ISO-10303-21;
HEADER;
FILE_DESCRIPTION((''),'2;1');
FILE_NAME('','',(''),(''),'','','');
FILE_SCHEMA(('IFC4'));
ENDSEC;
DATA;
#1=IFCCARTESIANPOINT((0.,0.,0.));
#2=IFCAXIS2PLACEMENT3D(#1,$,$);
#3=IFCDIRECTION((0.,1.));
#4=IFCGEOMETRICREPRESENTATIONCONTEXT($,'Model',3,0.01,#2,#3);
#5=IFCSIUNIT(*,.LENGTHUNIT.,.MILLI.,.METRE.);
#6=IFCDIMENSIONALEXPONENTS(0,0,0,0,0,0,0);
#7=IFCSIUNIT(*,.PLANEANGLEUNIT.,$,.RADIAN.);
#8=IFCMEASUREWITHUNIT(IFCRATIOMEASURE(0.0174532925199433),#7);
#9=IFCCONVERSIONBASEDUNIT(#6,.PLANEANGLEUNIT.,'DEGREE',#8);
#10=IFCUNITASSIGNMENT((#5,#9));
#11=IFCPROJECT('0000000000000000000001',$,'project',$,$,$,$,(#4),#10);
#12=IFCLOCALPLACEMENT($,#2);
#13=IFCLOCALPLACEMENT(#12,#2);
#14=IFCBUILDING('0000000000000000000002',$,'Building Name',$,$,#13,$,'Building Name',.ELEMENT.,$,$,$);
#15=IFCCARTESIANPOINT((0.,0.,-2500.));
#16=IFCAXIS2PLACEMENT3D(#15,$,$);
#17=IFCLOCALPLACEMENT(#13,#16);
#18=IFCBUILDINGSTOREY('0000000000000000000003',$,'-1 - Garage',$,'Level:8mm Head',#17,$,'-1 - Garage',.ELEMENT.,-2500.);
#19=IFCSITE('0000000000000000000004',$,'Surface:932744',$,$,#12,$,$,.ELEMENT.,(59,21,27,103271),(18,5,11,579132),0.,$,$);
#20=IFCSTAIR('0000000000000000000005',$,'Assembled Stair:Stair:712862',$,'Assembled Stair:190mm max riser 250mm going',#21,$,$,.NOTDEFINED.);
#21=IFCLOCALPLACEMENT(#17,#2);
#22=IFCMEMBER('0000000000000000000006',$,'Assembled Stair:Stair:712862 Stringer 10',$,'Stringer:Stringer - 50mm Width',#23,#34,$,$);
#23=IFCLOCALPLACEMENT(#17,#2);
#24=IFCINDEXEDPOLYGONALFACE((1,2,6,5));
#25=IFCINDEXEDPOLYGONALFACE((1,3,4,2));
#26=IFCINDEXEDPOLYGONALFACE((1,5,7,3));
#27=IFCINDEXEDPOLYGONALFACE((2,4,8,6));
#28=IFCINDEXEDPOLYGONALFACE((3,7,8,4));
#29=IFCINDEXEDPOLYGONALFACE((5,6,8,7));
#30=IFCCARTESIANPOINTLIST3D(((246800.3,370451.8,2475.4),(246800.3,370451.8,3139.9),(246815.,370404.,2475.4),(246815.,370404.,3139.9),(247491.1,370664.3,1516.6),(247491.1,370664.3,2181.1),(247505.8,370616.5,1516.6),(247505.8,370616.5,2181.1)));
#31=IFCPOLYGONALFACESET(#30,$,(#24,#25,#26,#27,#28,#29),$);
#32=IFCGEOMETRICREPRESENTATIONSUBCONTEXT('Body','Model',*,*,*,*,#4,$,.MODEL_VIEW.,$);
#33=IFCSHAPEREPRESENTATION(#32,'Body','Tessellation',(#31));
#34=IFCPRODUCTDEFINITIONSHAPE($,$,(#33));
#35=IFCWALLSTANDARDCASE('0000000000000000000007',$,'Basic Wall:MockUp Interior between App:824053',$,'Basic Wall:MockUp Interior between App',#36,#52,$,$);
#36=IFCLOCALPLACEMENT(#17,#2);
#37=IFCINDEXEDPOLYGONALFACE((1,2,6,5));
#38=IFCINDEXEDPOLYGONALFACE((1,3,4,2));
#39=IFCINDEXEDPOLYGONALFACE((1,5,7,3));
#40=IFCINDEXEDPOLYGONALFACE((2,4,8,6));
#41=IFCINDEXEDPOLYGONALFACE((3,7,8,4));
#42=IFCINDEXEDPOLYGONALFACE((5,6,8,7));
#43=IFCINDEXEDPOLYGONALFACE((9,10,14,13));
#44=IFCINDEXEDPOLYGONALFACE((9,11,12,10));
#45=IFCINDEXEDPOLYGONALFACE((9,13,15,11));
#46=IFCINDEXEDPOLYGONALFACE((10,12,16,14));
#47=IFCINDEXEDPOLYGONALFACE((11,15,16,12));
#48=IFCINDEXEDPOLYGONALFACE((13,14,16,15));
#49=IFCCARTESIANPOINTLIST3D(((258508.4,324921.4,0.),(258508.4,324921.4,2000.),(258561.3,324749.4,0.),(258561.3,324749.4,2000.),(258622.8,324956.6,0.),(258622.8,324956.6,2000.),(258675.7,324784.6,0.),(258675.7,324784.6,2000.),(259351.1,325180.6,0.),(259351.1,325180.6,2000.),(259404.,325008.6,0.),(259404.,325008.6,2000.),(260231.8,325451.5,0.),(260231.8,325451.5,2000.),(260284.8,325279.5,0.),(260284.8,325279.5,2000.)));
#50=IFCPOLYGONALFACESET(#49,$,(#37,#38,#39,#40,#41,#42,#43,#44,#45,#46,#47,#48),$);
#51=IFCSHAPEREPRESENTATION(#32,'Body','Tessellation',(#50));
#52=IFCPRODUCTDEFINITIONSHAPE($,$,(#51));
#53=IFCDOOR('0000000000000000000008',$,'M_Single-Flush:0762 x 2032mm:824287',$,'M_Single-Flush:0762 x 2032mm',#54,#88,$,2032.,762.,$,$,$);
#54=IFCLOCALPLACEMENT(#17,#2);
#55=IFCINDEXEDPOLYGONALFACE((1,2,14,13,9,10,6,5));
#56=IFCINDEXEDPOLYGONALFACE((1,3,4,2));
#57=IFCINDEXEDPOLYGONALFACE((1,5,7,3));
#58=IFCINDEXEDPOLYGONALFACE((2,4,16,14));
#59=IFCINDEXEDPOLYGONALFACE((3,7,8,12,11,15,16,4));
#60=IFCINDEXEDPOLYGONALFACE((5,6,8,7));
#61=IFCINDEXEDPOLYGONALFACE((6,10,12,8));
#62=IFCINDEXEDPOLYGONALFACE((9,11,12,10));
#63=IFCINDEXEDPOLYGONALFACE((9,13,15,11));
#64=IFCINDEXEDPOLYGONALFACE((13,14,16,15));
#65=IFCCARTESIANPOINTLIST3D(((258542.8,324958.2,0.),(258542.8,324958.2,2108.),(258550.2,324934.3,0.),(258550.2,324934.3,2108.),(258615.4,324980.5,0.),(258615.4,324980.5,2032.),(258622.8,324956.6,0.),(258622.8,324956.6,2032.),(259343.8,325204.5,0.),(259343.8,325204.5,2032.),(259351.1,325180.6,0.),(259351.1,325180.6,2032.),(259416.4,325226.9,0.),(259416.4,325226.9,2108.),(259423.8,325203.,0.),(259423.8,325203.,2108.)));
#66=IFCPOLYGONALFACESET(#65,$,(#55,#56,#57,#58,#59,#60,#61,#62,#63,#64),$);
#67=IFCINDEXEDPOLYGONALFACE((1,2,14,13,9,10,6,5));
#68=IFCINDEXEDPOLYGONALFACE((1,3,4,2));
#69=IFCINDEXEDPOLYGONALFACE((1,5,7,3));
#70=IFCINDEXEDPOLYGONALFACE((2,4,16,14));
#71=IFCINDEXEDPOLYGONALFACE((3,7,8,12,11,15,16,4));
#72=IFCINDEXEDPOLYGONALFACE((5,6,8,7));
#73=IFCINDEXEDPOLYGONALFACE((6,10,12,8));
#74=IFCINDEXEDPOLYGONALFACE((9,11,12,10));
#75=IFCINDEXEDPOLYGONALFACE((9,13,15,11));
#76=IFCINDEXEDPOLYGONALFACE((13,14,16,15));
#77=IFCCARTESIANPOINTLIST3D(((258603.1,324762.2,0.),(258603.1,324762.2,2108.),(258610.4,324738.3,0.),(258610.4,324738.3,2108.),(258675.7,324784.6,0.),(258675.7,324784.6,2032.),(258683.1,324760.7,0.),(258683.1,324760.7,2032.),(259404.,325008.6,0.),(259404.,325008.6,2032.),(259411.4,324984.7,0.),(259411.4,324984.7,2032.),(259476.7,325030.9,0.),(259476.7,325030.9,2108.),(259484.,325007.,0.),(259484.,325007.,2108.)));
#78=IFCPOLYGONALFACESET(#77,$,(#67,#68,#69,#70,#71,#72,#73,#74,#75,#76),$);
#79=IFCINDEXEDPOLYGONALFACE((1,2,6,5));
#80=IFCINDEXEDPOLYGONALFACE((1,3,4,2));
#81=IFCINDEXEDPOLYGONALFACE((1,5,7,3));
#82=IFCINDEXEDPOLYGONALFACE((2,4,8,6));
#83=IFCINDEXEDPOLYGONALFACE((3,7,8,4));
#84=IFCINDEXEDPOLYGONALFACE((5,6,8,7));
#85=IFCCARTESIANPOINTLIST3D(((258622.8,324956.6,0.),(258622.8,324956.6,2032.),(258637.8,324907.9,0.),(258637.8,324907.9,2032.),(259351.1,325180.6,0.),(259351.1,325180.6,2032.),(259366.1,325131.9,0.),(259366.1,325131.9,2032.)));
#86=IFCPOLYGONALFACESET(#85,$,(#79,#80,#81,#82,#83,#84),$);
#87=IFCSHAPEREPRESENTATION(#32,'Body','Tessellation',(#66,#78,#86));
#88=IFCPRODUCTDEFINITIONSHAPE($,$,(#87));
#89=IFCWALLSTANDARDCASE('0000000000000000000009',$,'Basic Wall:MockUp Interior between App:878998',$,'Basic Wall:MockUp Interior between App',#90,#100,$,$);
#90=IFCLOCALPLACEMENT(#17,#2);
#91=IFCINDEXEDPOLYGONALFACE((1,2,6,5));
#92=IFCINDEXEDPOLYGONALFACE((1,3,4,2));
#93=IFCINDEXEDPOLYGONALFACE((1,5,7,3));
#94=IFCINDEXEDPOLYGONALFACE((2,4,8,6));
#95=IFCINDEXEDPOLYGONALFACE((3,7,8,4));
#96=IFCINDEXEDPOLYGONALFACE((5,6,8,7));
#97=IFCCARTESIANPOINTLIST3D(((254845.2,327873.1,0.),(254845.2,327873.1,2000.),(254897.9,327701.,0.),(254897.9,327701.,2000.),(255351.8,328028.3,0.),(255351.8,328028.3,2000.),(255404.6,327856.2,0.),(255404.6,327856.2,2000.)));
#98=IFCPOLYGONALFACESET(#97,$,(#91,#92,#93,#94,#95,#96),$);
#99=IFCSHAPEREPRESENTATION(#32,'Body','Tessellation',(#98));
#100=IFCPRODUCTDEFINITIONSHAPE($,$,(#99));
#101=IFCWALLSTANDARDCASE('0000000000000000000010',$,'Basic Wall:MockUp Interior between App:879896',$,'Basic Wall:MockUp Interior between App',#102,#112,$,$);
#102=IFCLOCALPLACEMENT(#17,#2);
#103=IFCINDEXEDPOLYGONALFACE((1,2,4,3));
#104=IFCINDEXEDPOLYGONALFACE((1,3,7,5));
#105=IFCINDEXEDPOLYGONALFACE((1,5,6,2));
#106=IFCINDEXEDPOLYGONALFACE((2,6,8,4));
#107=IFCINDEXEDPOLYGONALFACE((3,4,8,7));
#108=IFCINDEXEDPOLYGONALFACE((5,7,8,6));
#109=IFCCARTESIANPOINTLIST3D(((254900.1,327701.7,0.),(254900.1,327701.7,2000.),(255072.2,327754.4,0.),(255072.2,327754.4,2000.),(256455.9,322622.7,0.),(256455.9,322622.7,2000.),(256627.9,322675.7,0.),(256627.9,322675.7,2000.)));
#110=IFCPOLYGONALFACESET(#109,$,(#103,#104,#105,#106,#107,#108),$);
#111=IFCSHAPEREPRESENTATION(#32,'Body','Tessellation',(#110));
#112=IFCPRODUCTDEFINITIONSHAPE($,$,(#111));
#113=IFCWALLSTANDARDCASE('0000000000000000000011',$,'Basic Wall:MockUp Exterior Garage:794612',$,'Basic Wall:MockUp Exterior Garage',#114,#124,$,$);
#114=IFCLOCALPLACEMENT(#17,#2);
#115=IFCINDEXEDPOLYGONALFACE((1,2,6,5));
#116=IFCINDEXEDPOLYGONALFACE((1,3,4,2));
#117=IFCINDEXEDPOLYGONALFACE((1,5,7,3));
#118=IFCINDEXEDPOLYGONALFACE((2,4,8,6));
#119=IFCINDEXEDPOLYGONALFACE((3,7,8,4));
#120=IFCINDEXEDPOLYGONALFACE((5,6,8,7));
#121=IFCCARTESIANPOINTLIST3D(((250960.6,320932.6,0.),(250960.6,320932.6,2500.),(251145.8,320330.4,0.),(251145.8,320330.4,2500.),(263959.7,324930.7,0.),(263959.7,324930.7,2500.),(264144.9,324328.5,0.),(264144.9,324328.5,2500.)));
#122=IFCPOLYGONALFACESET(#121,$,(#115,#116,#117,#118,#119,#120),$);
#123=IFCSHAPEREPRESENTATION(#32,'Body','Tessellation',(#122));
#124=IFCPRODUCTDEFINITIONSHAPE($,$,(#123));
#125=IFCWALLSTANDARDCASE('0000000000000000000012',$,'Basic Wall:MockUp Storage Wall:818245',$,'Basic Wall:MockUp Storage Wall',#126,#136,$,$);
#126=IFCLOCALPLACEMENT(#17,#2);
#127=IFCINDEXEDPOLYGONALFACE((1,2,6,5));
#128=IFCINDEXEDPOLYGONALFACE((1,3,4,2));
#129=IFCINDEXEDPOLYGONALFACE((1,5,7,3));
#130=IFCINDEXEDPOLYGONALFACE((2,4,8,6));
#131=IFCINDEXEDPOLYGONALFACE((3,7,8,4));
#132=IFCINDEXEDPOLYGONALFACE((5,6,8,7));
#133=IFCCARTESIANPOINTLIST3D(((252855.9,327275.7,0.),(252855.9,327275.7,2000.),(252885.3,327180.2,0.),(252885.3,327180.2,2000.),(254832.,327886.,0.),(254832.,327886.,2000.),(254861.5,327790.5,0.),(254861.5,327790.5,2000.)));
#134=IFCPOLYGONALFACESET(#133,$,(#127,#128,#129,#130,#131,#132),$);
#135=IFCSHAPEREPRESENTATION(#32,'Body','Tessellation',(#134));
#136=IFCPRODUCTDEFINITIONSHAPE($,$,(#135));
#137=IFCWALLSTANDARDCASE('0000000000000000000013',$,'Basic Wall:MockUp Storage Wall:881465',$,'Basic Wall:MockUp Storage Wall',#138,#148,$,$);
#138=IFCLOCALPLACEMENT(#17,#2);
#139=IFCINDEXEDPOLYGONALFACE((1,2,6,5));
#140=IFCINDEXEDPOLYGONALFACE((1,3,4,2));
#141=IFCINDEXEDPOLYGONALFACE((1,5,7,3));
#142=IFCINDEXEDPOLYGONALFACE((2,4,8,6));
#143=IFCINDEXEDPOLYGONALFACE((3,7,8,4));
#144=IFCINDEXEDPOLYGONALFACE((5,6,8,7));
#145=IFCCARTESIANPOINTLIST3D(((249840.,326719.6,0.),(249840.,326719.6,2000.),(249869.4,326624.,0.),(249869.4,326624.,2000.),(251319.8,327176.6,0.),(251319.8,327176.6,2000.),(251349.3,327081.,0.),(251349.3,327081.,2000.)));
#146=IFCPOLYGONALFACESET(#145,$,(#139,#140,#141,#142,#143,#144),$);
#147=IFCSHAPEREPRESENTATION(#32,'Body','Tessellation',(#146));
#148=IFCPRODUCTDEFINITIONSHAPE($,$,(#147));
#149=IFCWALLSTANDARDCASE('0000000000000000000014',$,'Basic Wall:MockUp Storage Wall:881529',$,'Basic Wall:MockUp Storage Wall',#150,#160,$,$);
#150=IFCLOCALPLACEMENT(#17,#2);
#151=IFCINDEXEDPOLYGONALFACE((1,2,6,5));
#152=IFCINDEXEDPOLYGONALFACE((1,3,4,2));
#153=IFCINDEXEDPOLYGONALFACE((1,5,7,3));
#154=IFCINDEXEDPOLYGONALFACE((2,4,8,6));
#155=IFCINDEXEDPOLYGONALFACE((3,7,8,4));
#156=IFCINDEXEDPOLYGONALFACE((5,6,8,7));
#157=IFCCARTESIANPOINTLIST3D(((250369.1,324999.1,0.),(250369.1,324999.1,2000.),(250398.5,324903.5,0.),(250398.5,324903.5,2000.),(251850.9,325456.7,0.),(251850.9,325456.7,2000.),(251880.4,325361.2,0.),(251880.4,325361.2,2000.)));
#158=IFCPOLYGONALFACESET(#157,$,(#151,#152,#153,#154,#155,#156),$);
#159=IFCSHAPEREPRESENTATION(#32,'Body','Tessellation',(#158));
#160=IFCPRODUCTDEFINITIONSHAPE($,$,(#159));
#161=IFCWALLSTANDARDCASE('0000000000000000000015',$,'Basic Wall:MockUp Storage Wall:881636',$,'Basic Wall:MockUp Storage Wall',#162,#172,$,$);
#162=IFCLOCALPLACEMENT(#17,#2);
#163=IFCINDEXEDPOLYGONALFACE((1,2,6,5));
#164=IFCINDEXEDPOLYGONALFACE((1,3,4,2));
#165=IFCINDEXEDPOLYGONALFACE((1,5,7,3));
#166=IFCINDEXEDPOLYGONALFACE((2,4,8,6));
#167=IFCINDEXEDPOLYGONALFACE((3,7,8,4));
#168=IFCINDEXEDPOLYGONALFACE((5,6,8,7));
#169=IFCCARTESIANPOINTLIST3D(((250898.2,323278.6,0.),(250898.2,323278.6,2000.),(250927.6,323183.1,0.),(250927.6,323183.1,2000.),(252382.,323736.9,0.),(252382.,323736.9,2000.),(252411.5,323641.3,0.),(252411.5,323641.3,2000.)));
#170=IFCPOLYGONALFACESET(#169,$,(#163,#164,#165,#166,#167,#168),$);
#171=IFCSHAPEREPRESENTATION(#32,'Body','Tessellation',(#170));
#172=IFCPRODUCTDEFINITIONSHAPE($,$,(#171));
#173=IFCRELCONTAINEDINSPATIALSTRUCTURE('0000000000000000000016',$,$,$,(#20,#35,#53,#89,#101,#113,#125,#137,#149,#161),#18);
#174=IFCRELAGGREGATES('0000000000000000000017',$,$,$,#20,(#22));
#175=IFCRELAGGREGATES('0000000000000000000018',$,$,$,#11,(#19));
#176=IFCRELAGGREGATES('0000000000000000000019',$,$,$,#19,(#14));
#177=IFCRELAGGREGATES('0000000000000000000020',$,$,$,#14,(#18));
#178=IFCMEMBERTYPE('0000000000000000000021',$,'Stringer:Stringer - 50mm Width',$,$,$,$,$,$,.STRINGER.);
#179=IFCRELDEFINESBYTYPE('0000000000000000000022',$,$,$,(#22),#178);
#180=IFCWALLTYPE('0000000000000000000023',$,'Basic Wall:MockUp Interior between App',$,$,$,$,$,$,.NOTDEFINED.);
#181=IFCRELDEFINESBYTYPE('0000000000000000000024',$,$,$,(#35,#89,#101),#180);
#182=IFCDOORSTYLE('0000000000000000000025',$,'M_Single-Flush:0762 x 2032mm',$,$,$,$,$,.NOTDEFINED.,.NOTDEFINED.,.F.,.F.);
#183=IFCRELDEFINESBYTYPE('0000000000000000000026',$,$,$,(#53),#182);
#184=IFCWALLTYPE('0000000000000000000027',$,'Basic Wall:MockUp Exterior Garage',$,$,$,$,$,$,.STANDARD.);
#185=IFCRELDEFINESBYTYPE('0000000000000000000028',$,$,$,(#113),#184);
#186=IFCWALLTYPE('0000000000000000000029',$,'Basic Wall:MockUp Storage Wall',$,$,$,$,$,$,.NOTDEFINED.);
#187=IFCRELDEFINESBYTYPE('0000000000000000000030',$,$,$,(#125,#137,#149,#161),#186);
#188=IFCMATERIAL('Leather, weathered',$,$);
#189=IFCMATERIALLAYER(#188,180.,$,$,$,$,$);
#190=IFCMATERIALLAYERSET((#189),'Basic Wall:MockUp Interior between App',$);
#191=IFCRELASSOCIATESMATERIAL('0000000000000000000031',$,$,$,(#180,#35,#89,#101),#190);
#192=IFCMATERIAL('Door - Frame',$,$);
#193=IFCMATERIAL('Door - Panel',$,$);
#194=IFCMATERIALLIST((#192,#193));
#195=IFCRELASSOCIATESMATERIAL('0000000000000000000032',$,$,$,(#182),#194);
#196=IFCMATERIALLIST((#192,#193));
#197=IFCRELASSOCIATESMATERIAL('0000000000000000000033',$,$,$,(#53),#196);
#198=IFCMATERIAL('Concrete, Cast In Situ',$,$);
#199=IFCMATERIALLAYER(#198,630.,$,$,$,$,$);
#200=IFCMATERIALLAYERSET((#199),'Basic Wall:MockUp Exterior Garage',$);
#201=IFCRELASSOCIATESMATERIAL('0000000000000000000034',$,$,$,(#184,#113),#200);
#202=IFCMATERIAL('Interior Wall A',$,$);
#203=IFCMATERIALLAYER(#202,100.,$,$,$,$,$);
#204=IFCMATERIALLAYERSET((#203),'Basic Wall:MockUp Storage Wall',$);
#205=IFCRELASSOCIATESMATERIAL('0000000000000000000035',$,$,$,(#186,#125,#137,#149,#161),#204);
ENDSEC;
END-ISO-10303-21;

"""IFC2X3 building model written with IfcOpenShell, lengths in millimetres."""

from ifc_helpers import new_model, entity, si_unit, converted_unit, direction, frame, frame_2d, origin, place, context, subcontext, project, spatial, polyline, rectangle, outline, extrude, source, transform, mapped, material, material_list, layer, layer_set, layer_usage, type_object, type_shapes, element, fill, aggregate, save


model = new_model("IFC2X3")

# Units and contexts
model_context = context("Model", 3, precision=0.01, world=origin(), true_north=direction((0.0, 1.0)))
body_context = subcontext(model_context, "Body", "Model", "MODEL_VIEW")
ifc_project = project(units=[si_unit("LENGTHUNIT", "METRE", prefix="MILLI"), converted_unit("PLANEANGLEUNIT", "DEGREE", entity("IfcRatioMeasure", 0.0174532925199433), si_unit("PLANEANGLEUNIT", "RADIAN"), dimensions=[0, 0, 0, 0, 0, 0, 0])], contexts=[model_context])

# Site, building, storey
site_placement = place(None, origin())
site = spatial("IfcSite", under=ifc_project, at=site_placement, Name="Surface:932744", CompositionType="ELEMENT", RefLatitude=(59, 21, 27, 103271), RefLongitude=(18, 5, 11, 579132), RefElevation=0.0)
building_placement = place(site_placement, origin())
building = spatial("IfcBuilding", under=site, at=building_placement, Name="Building Name", LongName="Building Name", CompositionType="ELEMENT")
storey_placement = place(building_placement, frame((0.0, 0.0, -2500.0)))
storey = spatial("IfcBuildingStorey", under=building, at=storey_placement, Name="-1 - Garage", ObjectType="Level:8mm Head", LongName="-1 - Garage", CompositionType="ELEMENT", Elevation=-2500.0)

# Stair, member
stair_placement = place(storey_placement, origin())
stair = element("IfcStair", 1, at=stair_placement, inside=storey, Name="Assembled Stair:Stair:712862", ObjectType="Assembled Stair:190mm max riser 250mm going", ShapeType="NOTDEFINED")
member_type = type_object("IfcMemberType", Name="Stringer:Stringer - 50mm Width", PredefinedType="STRINGER")
member_placement = place(stair_placement, origin())
member = element("IfcMember", 2, at=member_placement, type_object=member_type, Name="Assembled Stair:Stair:712862 Stringer 10", ObjectType="Stringer:Stringer - 50mm Width", context=body_context, shape_type="SweptSolid", body=[
    extrude(outline(polyline([(-865.7, -200.0), (335.0, -200.0), (865.7, 200.0), (-335.0, 200.0), (-865.7, -200.0)])), frame((247160.4, 370510.3, 2328.2), z_axis=(-0.29398, 0.955811, 0.0), x_axis=(-0.575299, -0.176946, 0.798574)), (0.0, 0.0, 1.0), 50.0),
])
aggregate(stair, [member])

# Shared definitions
ifc_material_1 = material(Name="Concrete, Cast In Situ")

# Wall, opening, door
ifc_material_2 = material(Name="Leather, weathered")
ifc_layer_1 = layer(ifc_material_2, 180.0)
ifc_layer_set_1 = layer_set([ifc_layer_1], Name="Basic Wall:MockUp Interior between App")
ifc_layer_usage_1 = layer_usage(ifc_layer_set_1, "AXIS2", "NEGATIVE", 90.0)
wall_type_1 = type_object("IfcWallType", Name="Basic Wall:MockUp Interior between App", PredefinedType="NOTDEFINED", material=ifc_layer_set_1)
wall_1_placement = place(storey_placement, frame((258534.8, 324835.4, 0.0), z_axis=(0.0, 0.0, 1.0), x_axis=(0.955811, 0.29398, 0.0)))
wall_1 = element("IfcWallStandardCase", 3, at=wall_1_placement, inside=storey, type_object=wall_type_1, material=ifc_layer_usage_1, Name="Basic Wall:MockUp Interior between App:824053", ObjectType="Basic Wall:MockUp Interior between App", context=body_context, shape_type="SweptSolid", body=[
    extrude(rectangle(XDim=1803.2, YDim=180.0, at=frame_2d((901.6, 0.0), x_axis=(-1.0, 0.0))), origin(), (0.0, 0.0, 1.0), 2000.0),
])
opening_placement = place(wall_1_placement, frame((119.7, -90.0, 0.0)))
opening = element("IfcOpeningElement", 4, at=opening_placement, cuts=wall_1, ObjectType="Opening", context=body_context, shape_type="SweptSolid", body=[
    extrude(rectangle(XDim=762.0, YDim=2032.0, at=frame_2d((1016.0, 381.0), x_axis=(0.0, -1.0))), frame((0.0, 0.0, 0.0), z_axis=(0.0, 1.0, 0.0), x_axis=(0.0, 0.0, 1.0)), (0.0, 0.0, 1.0), 180.0),
])
ifc_material_3 = material(Name="Door - Frame")
ifc_material_4 = material(Name="Door - Panel")
ifc_material_list_1 = material_list([ifc_material_3, ifc_material_4])
ifc_material_list_2 = material_list([ifc_material_3, ifc_material_4])
door_style = type_object("IfcDoorStyle", Name="M_Single-Flush:0762 x 2032mm", ConstructionType="NOTDEFINED", OperationType="NOTDEFINED", ParameterTakesPrecedence=False, Sizeable=False, material=ifc_material_list_2)
shared_shape = source(origin(), body_context, "Body", "SweptSolid", [
    extrude(outline(polyline([(-457.0, -1073.0), (457.0, -1073.0), (457.0, 1035.0), (381.0, 1035.0), (381.0, -997.0), (-381.0, -997.0), (-381.0, 1035.0), (-457.0, 1035.0), (-457.0, -1073.0)])), frame((381.0, 205.0, 1035.0), z_axis=(0.0, -1.0, 0.0), x_axis=(-1.0, 0.0, 0.0)), (0.0, 0.0, 1.0), 25.0),
    extrude(outline(polyline([(-1073.0, -457.0), (1035.0, -457.0), (1035.0, -381.0), (-997.0, -381.0), (-997.0, 381.0), (1035.0, 381.0), (1035.0, 457.0), (-1073.0, 457.0), (-1073.0, -457.0)])), frame((381.0, 0.0, 1035.0), z_axis=(0.0, -1.0, 0.0), x_axis=(0.0, 0.0, -1.0)), (0.0, 0.0, 1.0), 25.0),
    extrude(rectangle(XDim=762.0, YDim=51.0, at=frame_2d((0.0, 0.0), x_axis=(1.0, 0.0))), frame((381.0, 154.5, 0.0)), (0.0, 0.0, 1.0), 2032.0),
])
type_shapes(door_style, [shared_shape])
door_placement = place(opening_placement, origin())
door = element("IfcDoor", 5, at=door_placement, inside=storey, type_object=door_style, material=ifc_material_list_1, Name="M_Single-Flush:0762 x 2032mm:824287", ObjectType="M_Single-Flush:0762 x 2032mm", OverallHeight=2032.0, OverallWidth=762.0, context=body_context, shape_type="MappedRepresentation", body=[
    mapped(shared_shape, transform((0.0, 0.0, 0.0), scale=1.0)),
])
fill(opening, door)

# Walls
ifc_layer_usage_2 = layer_usage(ifc_layer_set_1, "AXIS2", "NEGATIVE", 90.0)
wall_2_placement = place(storey_placement, frame((255378.2, 327942.3, 0.0), z_axis=(0.0, 0.0, 1.0), x_axis=(-0.956149, -0.29288, 0.0)))
element("IfcWallStandardCase", 6, at=wall_2_placement, inside=storey, type_object=wall_type_1, material=ifc_layer_usage_2, Name="Basic Wall:MockUp Interior between App:878998", ObjectType="Basic Wall:MockUp Interior between App", context=body_context, shape_type="SweptSolid", body=[
    extrude(rectangle(XDim=529.9, YDim=180.0, at=frame_2d((265.0, 0.0), x_axis=(-1.0, 0.0))), origin(), (0.0, 0.0, 1.0), 2000.0),
])
ifc_layer_usage_3 = layer_usage(ifc_layer_set_1, "AXIS2", "NEGATIVE", 90.0)
wall_3_placement = place(storey_placement, frame((254986.2, 327728.1, 0.0), z_axis=(0.0, 0.0, 1.0), x_axis=(0.29288, -0.956149, 0.0)))
element("IfcWallStandardCase", 7, at=wall_3_placement, inside=storey, type_object=wall_type_1, material=ifc_layer_usage_3, Name="Basic Wall:MockUp Interior between App:879896", ObjectType="Basic Wall:MockUp Interior between App", context=body_context, shape_type="SweptSolid", body=[
    extrude(outline(polyline([(5311.9, -90.0), (5311.7, 90.0), (0.0, 90.0), (0.0, -90.0), (5311.9, -90.0)])), origin(), (0.0, 0.0, 1.0), 2000.0),
])
ifc_layer_2 = layer(ifc_material_1, 630.0)
ifc_layer_set_2 = layer_set([ifc_layer_2], Name="Basic Wall:MockUp Exterior Garage")
ifc_layer_usage_4 = layer_usage(ifc_layer_set_2, "AXIS2", "POSITIVE", -315.0)
wall_type_2 = type_object("IfcWallType", Name="Basic Wall:MockUp Exterior Garage", PredefinedType="STANDARD", material=ifc_layer_set_2)
wall_4_placement = place(storey_placement, frame((264052.3, 324629.6, 0.0), z_axis=(0.0, 0.0, 1.0), x_axis=(-0.955811, -0.29398, 0.0)))
element("IfcWallStandardCase", 8, at=wall_4_placement, inside=storey, type_object=wall_type_2, material=ifc_layer_usage_4, Name="Basic Wall:MockUp Exterior Garage:794612", ObjectType="Basic Wall:MockUp Exterior Garage", context=body_context, shape_type="SweptSolid", body=[
    extrude(rectangle(XDim=13600.0, YDim=630.0, at=frame_2d((6800.0, 0.0), x_axis=(-1.0, 0.0))), origin(), (0.0, 0.0, 1.0), 2500.0),
])
ifc_material_5 = material(Name="Interior Wall A")
ifc_layer_3 = layer(ifc_material_5, 100.0)
ifc_layer_set_3 = layer_set([ifc_layer_3], Name="Basic Wall:MockUp Storage Wall")
ifc_layer_usage_5 = layer_usage(ifc_layer_set_3, "AXIS2", "NEGATIVE", 50.0)
wall_type_3 = type_object("IfcWallType", Name="Basic Wall:MockUp Storage Wall", PredefinedType="NOTDEFINED", material=ifc_layer_set_3)
wall_5_placement = place(storey_placement, frame((252870.5, 327227.9, 0.0), z_axis=(0.0, 0.0, 1.0), x_axis=(0.955473, 0.29508, 0.0)))
element("IfcWallStandardCase", 9, at=wall_5_placement, inside=storey, type_object=wall_type_3, material=ifc_layer_usage_5, Name="Basic Wall:MockUp Storage Wall:818245", ObjectType="Basic Wall:MockUp Storage Wall", context=body_context, shape_type="SweptSolid", body=[
    extrude(outline(polyline([(2068.3, -50.0), (2068.3, 50.0), (0.1, 50.0), (0.0, -50.0), (2068.3, -50.0)])), origin(), (0.0, 0.0, 1.0), 2000.0),
])
ifc_layer_usage_6 = layer_usage(ifc_layer_set_3, "AXIS2", "NEGATIVE", 50.0)
wall_6_placement = place(storey_placement, frame((251334.5, 327128.8, 0.0), z_axis=(0.0, 0.0, 1.0), x_axis=(-0.955473, -0.29508, 0.0)))
element("IfcWallStandardCase", 10, at=wall_6_placement, inside=storey, type_object=wall_type_3, material=ifc_layer_usage_6, Name="Basic Wall:MockUp Storage Wall:881465", ObjectType="Basic Wall:MockUp Storage Wall", context=body_context, shape_type="SweptSolid", body=[
    extrude(outline(polyline([(1548.7, -50.0), (1548.8, 50.0), (0.0, 50.0), (0.0, -50.0), (1548.7, -50.0)])), origin(), (0.0, 0.0, 1.0), 2000.0),
])
ifc_layer_usage_7 = layer_usage(ifc_layer_set_3, "AXIS2", "NEGATIVE", 50.0)
wall_7_placement = place(storey_placement, frame((251865.6, 325409.0, 0.0), z_axis=(0.0, 0.0, 1.0), x_axis=(-0.955473, -0.29508, 0.0)))
element("IfcWallStandardCase", 11, at=wall_7_placement, inside=storey, type_object=wall_type_3, material=ifc_layer_usage_7, Name="Basic Wall:MockUp Storage Wall:881529", ObjectType="Basic Wall:MockUp Storage Wall", context=body_context, shape_type="SweptSolid", body=[
    extrude(outline(polyline([(1550.8, -50.0), (1550.9, 50.0), (0.0, 50.0), (0.0, -50.0), (1550.8, -50.0)])), origin(), (0.0, 0.0, 1.0), 2000.0),
])
ifc_layer_usage_8 = layer_usage(ifc_layer_set_3, "AXIS2", "NEGATIVE", 50.0)
wall_8_placement = place(storey_placement, frame((252396.8, 323689.1, 0.0), z_axis=(0.0, 0.0, 1.0), x_axis=(-0.955473, -0.29508, 0.0)))
element("IfcWallStandardCase", 12, at=wall_8_placement, inside=storey, type_object=wall_type_3, material=ifc_layer_usage_8, Name="Basic Wall:MockUp Storage Wall:881636", ObjectType="Basic Wall:MockUp Storage Wall", context=body_context, shape_type="SweptSolid", body=[
    extrude(outline(polyline([(1552.9, -50.0), (1553.1, 50.0), (0.0, 50.0), (0.0, -50.0), (1552.9, -50.0)])), origin(), (0.0, 0.0, 1.0), 2000.0),
])

save(model, "model.ifc")
